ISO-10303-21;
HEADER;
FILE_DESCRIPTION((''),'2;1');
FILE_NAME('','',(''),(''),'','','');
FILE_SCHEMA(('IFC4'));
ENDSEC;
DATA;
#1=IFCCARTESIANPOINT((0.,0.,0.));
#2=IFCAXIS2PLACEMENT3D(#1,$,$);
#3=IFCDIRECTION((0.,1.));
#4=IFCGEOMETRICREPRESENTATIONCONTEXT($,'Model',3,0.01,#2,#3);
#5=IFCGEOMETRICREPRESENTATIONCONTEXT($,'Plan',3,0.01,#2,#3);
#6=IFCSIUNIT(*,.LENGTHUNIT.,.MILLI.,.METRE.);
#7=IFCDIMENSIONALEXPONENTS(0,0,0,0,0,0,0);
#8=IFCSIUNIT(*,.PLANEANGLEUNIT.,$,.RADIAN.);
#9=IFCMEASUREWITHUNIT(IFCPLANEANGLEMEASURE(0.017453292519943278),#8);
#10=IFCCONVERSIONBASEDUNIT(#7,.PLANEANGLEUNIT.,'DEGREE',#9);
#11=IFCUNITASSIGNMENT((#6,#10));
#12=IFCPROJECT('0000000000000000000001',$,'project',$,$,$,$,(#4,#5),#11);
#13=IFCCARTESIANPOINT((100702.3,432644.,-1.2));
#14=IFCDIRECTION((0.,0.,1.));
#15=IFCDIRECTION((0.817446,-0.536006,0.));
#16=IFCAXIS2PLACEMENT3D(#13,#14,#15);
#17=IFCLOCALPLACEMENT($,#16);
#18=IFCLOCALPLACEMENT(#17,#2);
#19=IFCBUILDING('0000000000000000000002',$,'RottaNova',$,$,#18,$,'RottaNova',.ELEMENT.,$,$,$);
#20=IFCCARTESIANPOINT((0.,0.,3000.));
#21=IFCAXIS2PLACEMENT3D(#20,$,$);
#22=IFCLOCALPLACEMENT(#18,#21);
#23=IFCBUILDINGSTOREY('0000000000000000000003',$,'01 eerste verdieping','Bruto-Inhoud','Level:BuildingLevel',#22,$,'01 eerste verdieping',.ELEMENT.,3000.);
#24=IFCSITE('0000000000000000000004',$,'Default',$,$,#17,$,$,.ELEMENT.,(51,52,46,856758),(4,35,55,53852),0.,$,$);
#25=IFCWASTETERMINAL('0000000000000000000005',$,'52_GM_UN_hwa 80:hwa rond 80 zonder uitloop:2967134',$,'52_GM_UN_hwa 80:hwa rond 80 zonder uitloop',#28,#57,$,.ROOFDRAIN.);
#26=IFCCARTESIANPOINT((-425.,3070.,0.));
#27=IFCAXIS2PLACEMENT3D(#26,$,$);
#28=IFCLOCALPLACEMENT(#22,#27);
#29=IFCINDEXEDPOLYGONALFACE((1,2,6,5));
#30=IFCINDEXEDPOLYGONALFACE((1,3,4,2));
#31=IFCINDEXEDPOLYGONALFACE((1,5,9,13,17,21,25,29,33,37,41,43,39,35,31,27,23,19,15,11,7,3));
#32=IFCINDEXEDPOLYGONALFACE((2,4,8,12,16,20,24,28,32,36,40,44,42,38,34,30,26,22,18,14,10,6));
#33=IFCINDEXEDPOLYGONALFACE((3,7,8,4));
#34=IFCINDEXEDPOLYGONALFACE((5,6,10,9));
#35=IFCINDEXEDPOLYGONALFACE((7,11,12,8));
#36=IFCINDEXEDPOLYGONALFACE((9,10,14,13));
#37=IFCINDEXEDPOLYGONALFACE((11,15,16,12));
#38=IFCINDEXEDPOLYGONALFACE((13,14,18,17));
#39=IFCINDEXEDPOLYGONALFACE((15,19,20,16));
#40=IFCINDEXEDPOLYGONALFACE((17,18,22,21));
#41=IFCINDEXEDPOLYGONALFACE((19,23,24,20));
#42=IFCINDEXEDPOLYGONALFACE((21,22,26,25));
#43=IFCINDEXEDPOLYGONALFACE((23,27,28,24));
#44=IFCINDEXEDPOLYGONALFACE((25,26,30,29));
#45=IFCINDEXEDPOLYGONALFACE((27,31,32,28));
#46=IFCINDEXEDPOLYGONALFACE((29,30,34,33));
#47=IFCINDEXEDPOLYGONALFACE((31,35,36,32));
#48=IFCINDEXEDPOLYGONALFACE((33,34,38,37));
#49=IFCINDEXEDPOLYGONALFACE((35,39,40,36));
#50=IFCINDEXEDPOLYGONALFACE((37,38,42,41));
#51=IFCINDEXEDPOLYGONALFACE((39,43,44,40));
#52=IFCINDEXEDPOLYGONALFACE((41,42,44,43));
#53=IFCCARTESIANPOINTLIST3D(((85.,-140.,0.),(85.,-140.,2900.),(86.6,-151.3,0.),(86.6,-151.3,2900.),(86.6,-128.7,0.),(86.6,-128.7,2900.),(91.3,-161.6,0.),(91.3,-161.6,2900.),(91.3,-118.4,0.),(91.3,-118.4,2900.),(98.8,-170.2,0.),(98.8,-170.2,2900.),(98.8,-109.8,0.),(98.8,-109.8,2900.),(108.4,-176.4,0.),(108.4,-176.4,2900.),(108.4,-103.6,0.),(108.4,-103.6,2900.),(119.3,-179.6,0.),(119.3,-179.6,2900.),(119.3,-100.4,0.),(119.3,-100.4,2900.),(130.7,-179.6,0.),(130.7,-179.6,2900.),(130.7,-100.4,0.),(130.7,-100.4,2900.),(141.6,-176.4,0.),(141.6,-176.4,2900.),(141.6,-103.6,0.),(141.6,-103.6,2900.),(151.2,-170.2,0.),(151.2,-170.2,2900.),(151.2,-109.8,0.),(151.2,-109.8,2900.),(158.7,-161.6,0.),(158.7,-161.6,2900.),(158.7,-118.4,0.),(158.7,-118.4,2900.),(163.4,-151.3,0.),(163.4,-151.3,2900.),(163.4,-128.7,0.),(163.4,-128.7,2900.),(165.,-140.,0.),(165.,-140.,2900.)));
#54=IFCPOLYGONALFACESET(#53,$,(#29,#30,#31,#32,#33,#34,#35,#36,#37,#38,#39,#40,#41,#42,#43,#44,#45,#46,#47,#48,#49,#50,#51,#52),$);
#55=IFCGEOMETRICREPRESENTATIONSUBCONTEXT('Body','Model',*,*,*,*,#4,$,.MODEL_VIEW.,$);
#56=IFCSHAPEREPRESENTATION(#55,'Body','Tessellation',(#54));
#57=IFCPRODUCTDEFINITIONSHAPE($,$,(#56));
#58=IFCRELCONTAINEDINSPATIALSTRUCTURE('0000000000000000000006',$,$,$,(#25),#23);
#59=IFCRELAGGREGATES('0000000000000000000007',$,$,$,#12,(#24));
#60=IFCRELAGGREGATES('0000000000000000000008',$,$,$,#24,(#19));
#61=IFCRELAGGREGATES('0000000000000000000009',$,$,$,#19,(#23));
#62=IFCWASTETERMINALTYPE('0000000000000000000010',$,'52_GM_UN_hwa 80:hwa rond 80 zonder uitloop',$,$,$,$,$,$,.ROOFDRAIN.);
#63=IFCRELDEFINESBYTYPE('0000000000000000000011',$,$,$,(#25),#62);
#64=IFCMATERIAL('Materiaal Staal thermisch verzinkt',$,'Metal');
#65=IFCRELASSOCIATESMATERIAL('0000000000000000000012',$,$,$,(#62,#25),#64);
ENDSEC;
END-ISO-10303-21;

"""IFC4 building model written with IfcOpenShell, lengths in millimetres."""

from ifc_helpers import new_model, entity, si_unit, converted_unit, direction, frame, origin, place, context, subcontext, project, spatial, arc, indexed_curve, outline, extrude, source, transform, mapped, material, type_object, type_shapes, element, save


model = new_model("IFC4")

# Units and contexts
model_context = context("Model", 3, precision=0.01, world=origin(), true_north=direction((0.0, 1.0)))
plan_context = context("Plan", 3, precision=0.01, world=origin(), true_north=direction((0.0, 1.0)))
body_context = subcontext(model_context, "Body", "Model", "MODEL_VIEW")
ifc_project = project(units=[si_unit("LENGTHUNIT", "METRE", prefix="MILLI"), converted_unit("PLANEANGLEUNIT", "DEGREE", entity("IfcPlaneAngleMeasure", 0.017453292519943278), si_unit("PLANEANGLEUNIT", "RADIAN"), dimensions=[0, 0, 0, 0, 0, 0, 0])], contexts=[model_context, plan_context])

# Site, building, storey
site_placement = place(None, frame((100702.3, 432644.0, -1.2), z_axis=(0.0, 0.0, 1.0), x_axis=(0.817446, -0.536006, 0.0)))
site = spatial("IfcSite", under=ifc_project, at=site_placement, Name="Default", CompositionType="ELEMENT", RefLatitude=(51, 52, 46, 856758), RefLongitude=(4, 35, 55, 53852), RefElevation=0.0)
building_placement = place(site_placement, origin())
building = spatial("IfcBuilding", under=site, at=building_placement, Name="RottaNova", LongName="RottaNova", CompositionType="ELEMENT")
storey_placement = place(building_placement, frame((0.0, 0.0, 3000.0)))
storey = spatial("IfcBuildingStorey", under=building, at=storey_placement, Name="01 eerste verdieping", Description="Bruto-Inhoud", ObjectType="Level:BuildingLevel", LongName="01 eerste verdieping", CompositionType="ELEMENT", Elevation=3000.0)

# Waste terminal
ifc_material_1 = material(Name="Materiaal Staal thermisch verzinkt", Category="Metal")
waste_terminal_type = type_object("IfcWasteTerminalType", Name="52_GM_UN_hwa 80:hwa rond 80 zonder uitloop", PredefinedType="ROOFDRAIN", material=ifc_material_1)
shared_shape_1 = source(origin(), body_context, "Body", "SweptSolid", [
    extrude(outline(indexed_curve([(-40.0, 0.0), (0.0, -40.0), (40.0, 0.0), (0.0, 40.0)], segments=[arc(1, 2, 3), arc(3, 4, 1)], self_intersect=False)), frame((125.0, -140.0, 0.0)), (0.0, 0.0, 1.0), 2900.0),
])
type_shapes(waste_terminal_type, [shared_shape_1])
waste_terminal_placement = place(storey_placement, frame((-425.0, 3070.0, 0.0)))
element("IfcWasteTerminal", 1, at=waste_terminal_placement, inside=storey, type_object=waste_terminal_type, material=ifc_material_1, Name="52_GM_UN_hwa 80:hwa rond 80 zonder uitloop:2967134", ObjectType="52_GM_UN_hwa 80:hwa rond 80 zonder uitloop", PredefinedType="ROOFDRAIN", context=body_context, shape_type="MappedRepresentation", body=[
    mapped(shared_shape_1, transform((0.0, 0.0, 0.0), scale=1.0)),
])

save(model, "model.ifc")
